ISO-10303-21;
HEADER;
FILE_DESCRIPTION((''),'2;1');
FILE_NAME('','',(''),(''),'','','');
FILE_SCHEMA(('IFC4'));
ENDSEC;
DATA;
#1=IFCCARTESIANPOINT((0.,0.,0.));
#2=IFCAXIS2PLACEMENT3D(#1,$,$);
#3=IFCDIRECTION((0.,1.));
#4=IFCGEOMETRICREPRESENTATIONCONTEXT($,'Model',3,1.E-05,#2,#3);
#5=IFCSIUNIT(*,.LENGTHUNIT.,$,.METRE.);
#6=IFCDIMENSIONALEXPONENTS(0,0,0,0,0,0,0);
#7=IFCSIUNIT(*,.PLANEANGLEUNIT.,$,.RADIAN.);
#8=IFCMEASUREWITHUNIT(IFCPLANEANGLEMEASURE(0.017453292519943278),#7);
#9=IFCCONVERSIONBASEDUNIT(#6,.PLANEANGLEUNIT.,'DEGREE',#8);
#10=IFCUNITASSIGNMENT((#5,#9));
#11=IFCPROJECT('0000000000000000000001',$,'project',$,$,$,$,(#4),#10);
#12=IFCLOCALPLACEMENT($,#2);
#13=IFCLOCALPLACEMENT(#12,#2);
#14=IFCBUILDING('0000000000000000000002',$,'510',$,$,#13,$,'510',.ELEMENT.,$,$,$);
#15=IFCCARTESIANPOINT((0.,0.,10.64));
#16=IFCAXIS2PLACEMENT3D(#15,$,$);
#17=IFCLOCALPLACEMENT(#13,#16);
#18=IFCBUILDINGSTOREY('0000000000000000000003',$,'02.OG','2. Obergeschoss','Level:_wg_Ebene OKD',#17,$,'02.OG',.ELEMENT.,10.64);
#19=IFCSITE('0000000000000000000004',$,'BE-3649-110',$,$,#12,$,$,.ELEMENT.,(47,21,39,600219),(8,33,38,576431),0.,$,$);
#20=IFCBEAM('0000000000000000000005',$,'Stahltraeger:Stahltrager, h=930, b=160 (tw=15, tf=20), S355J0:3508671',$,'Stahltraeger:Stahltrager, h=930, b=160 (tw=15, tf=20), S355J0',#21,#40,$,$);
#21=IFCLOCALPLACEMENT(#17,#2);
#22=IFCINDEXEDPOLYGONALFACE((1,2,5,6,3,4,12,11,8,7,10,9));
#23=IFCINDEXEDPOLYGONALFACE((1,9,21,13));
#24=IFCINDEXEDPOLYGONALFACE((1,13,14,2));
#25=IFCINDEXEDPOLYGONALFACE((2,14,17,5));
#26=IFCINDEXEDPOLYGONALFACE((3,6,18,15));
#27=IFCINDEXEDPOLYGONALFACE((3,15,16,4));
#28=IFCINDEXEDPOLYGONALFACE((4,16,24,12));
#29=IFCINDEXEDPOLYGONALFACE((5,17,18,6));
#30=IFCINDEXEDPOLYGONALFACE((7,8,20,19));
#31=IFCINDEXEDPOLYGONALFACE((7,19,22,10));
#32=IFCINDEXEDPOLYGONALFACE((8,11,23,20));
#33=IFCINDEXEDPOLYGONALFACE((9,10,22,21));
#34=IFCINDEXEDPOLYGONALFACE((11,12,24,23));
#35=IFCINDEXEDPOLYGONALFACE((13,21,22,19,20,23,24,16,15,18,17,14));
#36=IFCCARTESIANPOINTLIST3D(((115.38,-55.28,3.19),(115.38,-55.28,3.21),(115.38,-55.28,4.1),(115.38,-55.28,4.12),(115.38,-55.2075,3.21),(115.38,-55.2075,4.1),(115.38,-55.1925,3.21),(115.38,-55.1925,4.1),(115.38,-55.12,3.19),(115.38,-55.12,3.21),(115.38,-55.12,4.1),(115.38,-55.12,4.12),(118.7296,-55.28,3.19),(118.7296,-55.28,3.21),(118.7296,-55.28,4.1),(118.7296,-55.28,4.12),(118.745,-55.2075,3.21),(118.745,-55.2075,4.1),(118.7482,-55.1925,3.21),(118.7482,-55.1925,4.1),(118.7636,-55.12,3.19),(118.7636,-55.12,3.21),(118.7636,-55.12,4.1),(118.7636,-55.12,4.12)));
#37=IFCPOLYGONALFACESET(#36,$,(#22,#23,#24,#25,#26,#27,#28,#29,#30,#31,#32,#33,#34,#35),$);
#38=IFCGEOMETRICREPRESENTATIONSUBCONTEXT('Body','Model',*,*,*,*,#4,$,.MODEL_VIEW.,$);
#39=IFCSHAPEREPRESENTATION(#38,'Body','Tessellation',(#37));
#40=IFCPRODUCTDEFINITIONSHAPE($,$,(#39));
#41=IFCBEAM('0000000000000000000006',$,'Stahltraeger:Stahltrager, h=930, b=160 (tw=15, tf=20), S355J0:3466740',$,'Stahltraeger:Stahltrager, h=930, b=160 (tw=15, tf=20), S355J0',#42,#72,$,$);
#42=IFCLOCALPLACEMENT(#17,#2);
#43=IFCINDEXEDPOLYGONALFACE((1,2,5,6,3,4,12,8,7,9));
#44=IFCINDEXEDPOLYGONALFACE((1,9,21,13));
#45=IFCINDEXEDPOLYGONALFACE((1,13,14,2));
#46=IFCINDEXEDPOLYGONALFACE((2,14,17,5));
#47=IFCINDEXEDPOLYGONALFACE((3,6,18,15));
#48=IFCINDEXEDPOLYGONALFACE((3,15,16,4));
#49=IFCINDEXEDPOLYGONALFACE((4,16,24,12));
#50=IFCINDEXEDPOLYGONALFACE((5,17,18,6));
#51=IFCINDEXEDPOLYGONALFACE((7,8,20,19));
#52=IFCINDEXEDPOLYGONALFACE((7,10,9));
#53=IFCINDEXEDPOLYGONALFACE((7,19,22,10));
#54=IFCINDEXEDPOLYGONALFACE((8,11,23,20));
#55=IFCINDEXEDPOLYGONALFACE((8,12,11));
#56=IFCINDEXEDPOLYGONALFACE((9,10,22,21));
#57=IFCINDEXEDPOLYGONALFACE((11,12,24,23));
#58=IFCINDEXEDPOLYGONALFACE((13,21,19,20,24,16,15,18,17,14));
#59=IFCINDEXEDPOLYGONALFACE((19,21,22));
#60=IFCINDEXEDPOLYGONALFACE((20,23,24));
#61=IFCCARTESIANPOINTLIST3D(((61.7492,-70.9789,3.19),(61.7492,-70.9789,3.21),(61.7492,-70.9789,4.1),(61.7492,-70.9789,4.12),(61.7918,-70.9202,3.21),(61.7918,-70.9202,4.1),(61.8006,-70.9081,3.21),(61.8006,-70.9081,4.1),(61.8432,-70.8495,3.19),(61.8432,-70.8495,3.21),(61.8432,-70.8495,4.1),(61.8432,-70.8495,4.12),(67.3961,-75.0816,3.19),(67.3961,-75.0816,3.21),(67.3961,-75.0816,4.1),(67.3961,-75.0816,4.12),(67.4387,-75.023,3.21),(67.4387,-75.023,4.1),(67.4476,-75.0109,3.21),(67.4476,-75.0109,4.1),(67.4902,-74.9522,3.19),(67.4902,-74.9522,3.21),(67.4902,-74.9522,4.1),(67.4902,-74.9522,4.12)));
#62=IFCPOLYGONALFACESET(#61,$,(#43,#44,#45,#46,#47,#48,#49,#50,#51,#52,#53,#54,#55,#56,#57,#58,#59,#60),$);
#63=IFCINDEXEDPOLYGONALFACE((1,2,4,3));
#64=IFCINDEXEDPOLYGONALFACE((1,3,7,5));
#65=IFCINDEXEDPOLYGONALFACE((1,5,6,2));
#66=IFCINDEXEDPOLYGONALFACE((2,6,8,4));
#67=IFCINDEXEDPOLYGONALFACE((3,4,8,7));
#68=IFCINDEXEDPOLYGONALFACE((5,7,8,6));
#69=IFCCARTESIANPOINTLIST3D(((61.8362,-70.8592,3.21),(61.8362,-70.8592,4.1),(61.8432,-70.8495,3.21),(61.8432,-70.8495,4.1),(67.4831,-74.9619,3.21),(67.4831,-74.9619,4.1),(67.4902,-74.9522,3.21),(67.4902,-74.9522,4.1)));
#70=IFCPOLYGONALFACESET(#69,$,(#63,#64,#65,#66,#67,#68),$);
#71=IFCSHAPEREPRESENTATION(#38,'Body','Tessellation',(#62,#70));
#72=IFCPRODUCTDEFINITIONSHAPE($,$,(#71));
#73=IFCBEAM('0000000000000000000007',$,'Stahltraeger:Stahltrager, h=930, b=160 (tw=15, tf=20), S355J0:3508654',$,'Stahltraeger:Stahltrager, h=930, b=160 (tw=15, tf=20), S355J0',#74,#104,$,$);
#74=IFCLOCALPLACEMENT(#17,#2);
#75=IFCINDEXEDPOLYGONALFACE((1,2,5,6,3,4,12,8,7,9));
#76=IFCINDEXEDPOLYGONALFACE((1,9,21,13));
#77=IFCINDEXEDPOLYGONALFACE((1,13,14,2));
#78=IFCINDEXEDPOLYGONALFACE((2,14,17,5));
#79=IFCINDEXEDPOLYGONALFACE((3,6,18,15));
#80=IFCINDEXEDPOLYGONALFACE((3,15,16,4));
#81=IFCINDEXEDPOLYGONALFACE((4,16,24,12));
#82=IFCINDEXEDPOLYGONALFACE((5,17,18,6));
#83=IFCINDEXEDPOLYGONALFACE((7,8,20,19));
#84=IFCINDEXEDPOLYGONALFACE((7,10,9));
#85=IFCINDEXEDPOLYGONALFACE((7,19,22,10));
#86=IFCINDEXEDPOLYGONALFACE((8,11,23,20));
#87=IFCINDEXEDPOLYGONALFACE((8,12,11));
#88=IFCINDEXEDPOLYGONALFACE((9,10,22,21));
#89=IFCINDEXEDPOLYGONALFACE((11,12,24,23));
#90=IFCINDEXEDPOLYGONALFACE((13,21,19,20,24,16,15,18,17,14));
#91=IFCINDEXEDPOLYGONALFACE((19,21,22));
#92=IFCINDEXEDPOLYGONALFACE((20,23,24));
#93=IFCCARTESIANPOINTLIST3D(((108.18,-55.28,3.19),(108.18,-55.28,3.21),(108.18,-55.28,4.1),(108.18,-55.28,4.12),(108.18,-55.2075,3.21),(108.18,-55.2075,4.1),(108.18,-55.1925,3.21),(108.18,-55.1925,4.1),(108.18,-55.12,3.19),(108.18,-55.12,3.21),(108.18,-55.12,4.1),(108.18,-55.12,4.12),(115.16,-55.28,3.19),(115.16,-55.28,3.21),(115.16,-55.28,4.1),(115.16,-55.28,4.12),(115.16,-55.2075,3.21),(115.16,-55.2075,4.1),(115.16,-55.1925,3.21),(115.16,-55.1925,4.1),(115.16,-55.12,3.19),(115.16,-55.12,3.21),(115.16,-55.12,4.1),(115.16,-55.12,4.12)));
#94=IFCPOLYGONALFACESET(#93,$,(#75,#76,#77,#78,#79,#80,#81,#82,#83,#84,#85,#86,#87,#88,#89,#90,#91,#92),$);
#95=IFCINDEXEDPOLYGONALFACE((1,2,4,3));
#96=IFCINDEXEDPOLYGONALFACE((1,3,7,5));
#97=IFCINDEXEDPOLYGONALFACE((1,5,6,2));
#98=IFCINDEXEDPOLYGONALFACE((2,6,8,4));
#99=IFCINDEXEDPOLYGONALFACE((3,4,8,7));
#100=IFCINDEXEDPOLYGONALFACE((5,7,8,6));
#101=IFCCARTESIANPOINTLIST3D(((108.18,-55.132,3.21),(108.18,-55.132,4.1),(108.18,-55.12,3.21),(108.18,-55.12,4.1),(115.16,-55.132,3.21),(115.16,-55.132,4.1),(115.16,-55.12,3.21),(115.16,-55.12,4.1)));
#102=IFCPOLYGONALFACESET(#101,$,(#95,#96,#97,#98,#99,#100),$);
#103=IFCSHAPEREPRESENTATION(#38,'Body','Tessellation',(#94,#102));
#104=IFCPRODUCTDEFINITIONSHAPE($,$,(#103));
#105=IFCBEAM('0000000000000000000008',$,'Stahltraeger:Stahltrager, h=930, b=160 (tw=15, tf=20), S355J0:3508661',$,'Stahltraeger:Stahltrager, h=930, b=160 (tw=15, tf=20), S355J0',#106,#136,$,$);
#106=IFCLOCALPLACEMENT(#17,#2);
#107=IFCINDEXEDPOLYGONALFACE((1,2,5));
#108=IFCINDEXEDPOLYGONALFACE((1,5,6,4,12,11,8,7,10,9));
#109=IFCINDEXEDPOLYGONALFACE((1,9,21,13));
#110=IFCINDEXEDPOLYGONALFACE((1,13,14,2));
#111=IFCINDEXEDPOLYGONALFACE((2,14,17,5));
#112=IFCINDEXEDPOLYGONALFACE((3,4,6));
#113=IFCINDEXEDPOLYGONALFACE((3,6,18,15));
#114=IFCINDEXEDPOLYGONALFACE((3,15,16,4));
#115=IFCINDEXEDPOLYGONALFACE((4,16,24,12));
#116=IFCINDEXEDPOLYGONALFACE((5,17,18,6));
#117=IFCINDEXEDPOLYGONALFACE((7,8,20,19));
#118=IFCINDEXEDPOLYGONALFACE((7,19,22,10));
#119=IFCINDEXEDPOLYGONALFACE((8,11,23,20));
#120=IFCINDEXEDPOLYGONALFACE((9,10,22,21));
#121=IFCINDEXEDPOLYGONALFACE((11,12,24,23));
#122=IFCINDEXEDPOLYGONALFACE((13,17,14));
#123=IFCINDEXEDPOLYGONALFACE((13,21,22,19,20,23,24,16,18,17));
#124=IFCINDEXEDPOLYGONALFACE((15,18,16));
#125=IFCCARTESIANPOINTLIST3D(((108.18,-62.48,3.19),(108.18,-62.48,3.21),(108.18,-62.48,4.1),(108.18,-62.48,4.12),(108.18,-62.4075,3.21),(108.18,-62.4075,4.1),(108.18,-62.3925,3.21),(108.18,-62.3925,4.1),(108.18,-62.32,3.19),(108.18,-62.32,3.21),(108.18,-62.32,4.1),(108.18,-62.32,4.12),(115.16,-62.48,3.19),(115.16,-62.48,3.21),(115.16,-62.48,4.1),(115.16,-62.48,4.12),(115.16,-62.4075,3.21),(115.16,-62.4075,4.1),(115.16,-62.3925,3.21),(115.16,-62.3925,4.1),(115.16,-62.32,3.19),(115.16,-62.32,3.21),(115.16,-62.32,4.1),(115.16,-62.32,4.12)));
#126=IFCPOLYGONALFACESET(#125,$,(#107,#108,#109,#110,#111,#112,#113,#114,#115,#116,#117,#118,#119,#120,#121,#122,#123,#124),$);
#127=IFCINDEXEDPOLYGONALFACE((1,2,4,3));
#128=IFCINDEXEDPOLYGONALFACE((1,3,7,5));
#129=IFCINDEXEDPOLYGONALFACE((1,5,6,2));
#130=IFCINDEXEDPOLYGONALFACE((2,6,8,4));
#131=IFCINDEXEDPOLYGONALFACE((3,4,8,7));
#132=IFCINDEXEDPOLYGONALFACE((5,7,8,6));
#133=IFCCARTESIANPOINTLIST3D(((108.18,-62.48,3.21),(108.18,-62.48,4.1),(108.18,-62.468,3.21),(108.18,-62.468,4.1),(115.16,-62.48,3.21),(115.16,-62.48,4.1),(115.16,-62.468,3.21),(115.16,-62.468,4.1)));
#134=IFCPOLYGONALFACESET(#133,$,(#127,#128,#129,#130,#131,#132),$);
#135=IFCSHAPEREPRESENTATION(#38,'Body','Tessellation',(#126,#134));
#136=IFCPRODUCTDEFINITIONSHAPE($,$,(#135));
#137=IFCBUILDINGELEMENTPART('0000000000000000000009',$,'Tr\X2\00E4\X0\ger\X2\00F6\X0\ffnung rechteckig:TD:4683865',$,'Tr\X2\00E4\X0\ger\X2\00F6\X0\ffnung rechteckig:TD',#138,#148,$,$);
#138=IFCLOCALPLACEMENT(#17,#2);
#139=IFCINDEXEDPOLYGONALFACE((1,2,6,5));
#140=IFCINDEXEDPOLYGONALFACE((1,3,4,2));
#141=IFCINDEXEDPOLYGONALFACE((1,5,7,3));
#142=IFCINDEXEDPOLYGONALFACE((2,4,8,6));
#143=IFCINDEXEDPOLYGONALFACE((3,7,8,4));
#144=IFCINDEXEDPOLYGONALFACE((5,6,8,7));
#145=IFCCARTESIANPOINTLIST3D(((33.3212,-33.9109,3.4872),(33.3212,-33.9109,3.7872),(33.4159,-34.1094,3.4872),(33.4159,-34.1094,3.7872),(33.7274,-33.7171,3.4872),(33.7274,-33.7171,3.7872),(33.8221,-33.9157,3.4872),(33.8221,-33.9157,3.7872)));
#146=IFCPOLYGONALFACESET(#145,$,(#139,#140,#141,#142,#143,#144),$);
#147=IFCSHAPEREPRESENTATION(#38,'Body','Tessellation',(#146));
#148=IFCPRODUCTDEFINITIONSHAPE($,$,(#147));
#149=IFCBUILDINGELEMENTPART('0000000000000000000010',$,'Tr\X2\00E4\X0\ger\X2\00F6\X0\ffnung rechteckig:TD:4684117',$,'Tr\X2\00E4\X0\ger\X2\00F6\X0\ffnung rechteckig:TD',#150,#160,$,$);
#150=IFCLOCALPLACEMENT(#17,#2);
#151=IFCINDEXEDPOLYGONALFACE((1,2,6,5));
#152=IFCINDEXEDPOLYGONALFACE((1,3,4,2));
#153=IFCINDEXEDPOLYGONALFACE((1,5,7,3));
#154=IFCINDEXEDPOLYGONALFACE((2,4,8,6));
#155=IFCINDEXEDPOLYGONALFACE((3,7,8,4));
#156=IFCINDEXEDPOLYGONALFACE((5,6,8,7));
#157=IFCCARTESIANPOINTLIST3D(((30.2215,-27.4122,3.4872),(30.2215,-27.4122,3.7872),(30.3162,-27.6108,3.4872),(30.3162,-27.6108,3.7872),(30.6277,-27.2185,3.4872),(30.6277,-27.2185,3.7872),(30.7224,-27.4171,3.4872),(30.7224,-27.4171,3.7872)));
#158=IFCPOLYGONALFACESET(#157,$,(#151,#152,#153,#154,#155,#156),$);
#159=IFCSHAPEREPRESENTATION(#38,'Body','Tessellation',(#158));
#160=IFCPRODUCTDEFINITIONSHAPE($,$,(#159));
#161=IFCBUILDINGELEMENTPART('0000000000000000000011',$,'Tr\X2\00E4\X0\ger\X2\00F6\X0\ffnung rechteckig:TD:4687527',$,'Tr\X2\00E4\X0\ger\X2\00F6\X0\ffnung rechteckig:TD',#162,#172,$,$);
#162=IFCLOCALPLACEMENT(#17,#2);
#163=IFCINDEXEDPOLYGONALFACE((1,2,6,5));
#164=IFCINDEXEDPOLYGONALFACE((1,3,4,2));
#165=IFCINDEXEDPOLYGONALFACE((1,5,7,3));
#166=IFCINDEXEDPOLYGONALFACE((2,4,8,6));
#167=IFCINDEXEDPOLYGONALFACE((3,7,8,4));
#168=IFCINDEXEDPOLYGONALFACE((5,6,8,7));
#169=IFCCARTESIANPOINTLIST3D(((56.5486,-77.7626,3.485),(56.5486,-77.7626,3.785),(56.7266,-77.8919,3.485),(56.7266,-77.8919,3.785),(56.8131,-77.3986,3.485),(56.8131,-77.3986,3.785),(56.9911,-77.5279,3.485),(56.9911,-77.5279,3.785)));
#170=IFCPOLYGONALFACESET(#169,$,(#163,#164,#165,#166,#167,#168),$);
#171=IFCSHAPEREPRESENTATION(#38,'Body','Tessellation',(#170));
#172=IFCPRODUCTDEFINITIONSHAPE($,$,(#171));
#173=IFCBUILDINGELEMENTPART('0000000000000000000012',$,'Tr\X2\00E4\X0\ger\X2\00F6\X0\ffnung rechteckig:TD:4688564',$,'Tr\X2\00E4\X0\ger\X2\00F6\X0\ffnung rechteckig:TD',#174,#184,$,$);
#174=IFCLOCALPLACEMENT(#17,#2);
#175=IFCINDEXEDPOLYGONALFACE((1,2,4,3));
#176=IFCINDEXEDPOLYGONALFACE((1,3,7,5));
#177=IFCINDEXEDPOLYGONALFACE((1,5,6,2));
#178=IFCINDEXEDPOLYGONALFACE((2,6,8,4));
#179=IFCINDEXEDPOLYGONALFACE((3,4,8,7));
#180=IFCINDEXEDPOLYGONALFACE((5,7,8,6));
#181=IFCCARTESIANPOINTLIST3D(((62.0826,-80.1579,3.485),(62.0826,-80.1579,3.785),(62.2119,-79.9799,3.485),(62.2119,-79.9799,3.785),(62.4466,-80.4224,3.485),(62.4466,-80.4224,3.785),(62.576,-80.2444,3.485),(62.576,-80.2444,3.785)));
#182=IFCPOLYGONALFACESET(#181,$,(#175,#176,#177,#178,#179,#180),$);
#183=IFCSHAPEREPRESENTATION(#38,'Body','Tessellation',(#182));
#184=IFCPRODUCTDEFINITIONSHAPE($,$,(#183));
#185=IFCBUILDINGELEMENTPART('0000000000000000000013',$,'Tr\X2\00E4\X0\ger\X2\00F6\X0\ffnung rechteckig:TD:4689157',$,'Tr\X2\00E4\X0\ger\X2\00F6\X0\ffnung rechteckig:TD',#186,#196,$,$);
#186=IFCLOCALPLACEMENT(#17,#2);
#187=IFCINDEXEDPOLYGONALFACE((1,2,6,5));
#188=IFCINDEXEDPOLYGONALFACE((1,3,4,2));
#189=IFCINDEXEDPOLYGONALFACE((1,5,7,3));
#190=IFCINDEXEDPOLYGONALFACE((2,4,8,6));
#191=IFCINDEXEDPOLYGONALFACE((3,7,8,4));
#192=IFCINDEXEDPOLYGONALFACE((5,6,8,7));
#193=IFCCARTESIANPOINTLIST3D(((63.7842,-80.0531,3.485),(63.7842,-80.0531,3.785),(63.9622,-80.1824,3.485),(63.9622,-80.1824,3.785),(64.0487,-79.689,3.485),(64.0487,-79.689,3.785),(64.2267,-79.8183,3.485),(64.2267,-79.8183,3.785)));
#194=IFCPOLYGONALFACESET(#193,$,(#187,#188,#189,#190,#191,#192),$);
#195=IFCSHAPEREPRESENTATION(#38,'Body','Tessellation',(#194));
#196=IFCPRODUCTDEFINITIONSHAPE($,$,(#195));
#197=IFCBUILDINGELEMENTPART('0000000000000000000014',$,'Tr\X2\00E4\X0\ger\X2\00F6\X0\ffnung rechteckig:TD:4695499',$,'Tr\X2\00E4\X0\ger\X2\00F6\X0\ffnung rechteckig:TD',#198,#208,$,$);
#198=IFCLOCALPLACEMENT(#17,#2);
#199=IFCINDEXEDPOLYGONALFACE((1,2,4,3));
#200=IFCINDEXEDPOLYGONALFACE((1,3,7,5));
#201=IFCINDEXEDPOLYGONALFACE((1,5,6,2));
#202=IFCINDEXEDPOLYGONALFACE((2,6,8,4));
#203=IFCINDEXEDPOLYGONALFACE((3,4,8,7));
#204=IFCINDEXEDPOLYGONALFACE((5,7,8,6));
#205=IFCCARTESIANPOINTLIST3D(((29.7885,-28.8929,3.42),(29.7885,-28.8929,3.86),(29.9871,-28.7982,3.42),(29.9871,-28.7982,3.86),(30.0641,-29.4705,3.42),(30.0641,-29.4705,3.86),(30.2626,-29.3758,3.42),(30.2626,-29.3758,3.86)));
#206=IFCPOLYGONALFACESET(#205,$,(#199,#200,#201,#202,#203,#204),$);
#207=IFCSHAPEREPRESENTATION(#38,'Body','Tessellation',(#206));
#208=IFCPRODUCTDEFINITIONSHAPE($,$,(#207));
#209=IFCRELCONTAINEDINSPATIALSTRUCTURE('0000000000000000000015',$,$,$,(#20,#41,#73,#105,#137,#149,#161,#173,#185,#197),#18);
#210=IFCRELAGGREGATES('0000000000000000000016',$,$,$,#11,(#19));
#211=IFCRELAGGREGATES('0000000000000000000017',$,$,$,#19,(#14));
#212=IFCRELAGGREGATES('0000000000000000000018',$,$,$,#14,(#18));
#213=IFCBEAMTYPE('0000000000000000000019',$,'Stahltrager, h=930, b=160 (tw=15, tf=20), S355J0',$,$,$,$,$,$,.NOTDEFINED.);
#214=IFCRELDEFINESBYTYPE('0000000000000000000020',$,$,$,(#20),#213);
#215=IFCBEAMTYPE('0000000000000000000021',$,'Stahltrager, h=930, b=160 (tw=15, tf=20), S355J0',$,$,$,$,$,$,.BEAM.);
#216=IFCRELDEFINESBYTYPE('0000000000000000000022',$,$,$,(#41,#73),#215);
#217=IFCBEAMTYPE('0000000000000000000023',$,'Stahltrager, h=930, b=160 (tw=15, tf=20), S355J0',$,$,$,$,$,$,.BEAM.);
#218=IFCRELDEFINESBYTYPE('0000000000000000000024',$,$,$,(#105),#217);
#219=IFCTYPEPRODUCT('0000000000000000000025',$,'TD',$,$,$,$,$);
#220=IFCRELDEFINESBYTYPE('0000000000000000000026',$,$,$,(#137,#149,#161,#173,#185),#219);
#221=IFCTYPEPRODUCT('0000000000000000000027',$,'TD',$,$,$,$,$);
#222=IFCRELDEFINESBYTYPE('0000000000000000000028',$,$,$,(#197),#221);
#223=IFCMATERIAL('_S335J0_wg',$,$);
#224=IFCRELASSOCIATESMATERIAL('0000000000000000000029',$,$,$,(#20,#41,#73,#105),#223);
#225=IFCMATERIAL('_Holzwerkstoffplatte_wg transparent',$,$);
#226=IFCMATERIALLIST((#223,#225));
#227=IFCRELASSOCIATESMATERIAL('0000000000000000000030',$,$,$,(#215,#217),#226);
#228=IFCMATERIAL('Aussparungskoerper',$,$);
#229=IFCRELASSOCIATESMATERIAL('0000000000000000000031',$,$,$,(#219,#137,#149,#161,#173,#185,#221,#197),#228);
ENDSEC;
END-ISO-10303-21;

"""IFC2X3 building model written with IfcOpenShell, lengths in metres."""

from ifc_helpers import new_model, entity, si_unit, converted_unit, direction, frame, frame_2d, origin, origin_2d_with_axis, place, context, subcontext, project, spatial, rectangle, i_section, extrude, clip, halfspace, source, transform, mapped, material, material_list, type_object, type_shapes, element, save


model = new_model("IFC2X3")

# Units and contexts
model_context = context("Model", 3, precision=1e-05, world=origin(), true_north=direction((0.0, 1.0)))
body_context = subcontext(model_context, "Body", "Model", "MODEL_VIEW")
ifc_project = project(units=[si_unit("LENGTHUNIT", "METRE"), converted_unit("PLANEANGLEUNIT", "DEGREE", entity("IfcPlaneAngleMeasure", 0.017453292519943278), si_unit("PLANEANGLEUNIT", "RADIAN"), dimensions=[0, 0, 0, 0, 0, 0, 0])], contexts=[model_context])

# Site, building, storey
site_placement = place(None, origin())
site = spatial("IfcSite", under=ifc_project, at=site_placement, Name="BE-3649-110", CompositionType="ELEMENT", RefLatitude=(47, 21, 39, 600219), RefLongitude=(8, 33, 38, 576431), RefElevation=0.0)
building_placement = place(site_placement, origin())
building = spatial("IfcBuilding", under=site, at=building_placement, Name="510", LongName="510", CompositionType="ELEMENT")
storey_placement = place(building_placement, frame((0.0, 0.0, 10.64)))
storey = spatial("IfcBuildingStorey", under=building, at=storey_placement, Name="02.OG", Description="2. Obergeschoss", ObjectType="Level:_wg_Ebene OKD", LongName="02.OG", CompositionType="ELEMENT", Elevation=10.64)

# Beams
ifc_material_1 = material(Name="_S335J0_wg")
beam_type_1 = type_object("IfcBeamType", Name="Stahltrager, h=930, b=160 (tw=15, tf=20), S355J0", PredefinedType="NOTDEFINED")
beam_1_placement = place(storey_placement, frame((115.38, -55.2, 4.12)))
element("IfcBeam", 1, at=beam_1_placement, inside=storey, type_object=beam_type_1, material=ifc_material_1, Name="Stahltraeger:Stahltrager, h=930, b=160 (tw=15, tf=20), S355J0:3508671", ObjectType="Stahltraeger:Stahltrager, h=930, b=160 (tw=15, tf=20), S355J0", context=body_context, shape_type="SweptSolid", body=[
    clip(extrude(i_section(OverallWidth=0.16, OverallDepth=0.93, WebThickness=0.015, FlangeThickness=0.02, at=frame_2d((0.0, 0.0), x_axis=(0.0, 1.0))), frame((0.0, 0.0, -0.465), z_axis=(1.0, 0.0, 0.0), x_axis=(0.0, 0.0, -1.0)), (0.0, 0.0, 1.0), 3.3836), halfspace(frame((3.2599, -0.5018, 10.02), z_axis=(0.978148, -0.207912, 0.0), x_axis=(0.207912, 0.978148, 0.0)), False)),
])
ifc_material_2 = material(Name="_Holzwerkstoffplatte_wg transparent")
ifc_material_list = material_list([ifc_material_1, ifc_material_2])
beam_type_2 = type_object("IfcBeamType", Name="Stahltrager, h=930, b=160 (tw=15, tf=20), S355J0", PredefinedType="BEAM", material=ifc_material_list)
shared_shape_1 = source(origin(), body_context, "Body", "SweptSolid", [
    extrude(i_section(OverallWidth=0.16, OverallDepth=0.93, WebThickness=0.015, FlangeThickness=0.02, at=frame_2d((0.0, 0.0), x_axis=(0.0, 1.0))), frame((-3.49, 0.0, 0.0), z_axis=(1.0, 0.0, 0.0), x_axis=(0.0, 0.0, -1.0)), (0.0, 0.0, 1.0), 6.98),
    extrude(rectangle(XDim=0.89, YDim=0.012, at=origin_2d_with_axis()), frame((-3.49, 0.074, 0.0), z_axis=(1.0, 0.0, 0.0), x_axis=(0.0, 0.0, -1.0)), (0.0, 0.0, 1.0), 6.98),
])
type_shapes(beam_type_2, [shared_shape_1])
beam_2_placement = place(storey_placement, frame((64.6197, -72.9655, 3.655), z_axis=(0.0, 0.0, 1.0), x_axis=(0.809017, -0.587785, 0.0)))
element("IfcBeam", 2, at=beam_2_placement, inside=storey, type_object=beam_type_2, material=ifc_material_1, Name="Stahltraeger:Stahltrager, h=930, b=160 (tw=15, tf=20), S355J0:3466740", ObjectType="Stahltraeger:Stahltrager, h=930, b=160 (tw=15, tf=20), S355J0", context=body_context, shape_type="MappedRepresentation", body=[
    mapped(shared_shape_1, transform((0.0, 0.0, 0.0), scale=1.0)),
])
beam_3_placement = place(storey_placement, frame((111.67, -55.2, 3.655)))
element("IfcBeam", 3, at=beam_3_placement, inside=storey, type_object=beam_type_2, material=ifc_material_1, Name="Stahltraeger:Stahltrager, h=930, b=160 (tw=15, tf=20), S355J0:3508654", ObjectType="Stahltraeger:Stahltrager, h=930, b=160 (tw=15, tf=20), S355J0", context=body_context, shape_type="MappedRepresentation", body=[
    mapped(shared_shape_1, transform((0.0, 0.0, 0.0), scale=1.0)),
])
beam_type_3 = type_object("IfcBeamType", Name="Stahltrager, h=930, b=160 (tw=15, tf=20), S355J0", PredefinedType="BEAM", material=ifc_material_list)
shared_shape_2 = source(origin(), body_context, "Body", "SweptSolid", [
    extrude(i_section(OverallWidth=0.16, OverallDepth=0.93, WebThickness=0.015, FlangeThickness=0.02, at=frame_2d((0.0, 0.0), x_axis=(0.0, 1.0))), frame((-3.49, 0.0, 0.0), z_axis=(1.0, 0.0, 0.0), x_axis=(0.0, 0.0, -1.0)), (0.0, 0.0, 1.0), 6.98),
    extrude(rectangle(XDim=0.89, YDim=0.012, at=frame_2d((0.0, 0.0), x_axis=(1.0, 0.0))), frame((-3.49, -0.074, 0.0), z_axis=(1.0, 0.0, 0.0), x_axis=(0.0, 0.0, -1.0)), (0.0, 0.0, 1.0), 6.98),
])
type_shapes(beam_type_3, [shared_shape_2])
beam_4_placement = place(storey_placement, frame((111.67, -62.4, 3.655)))
element("IfcBeam", 4, at=beam_4_placement, inside=storey, type_object=beam_type_3, material=ifc_material_1, Name="Stahltraeger:Stahltrager, h=930, b=160 (tw=15, tf=20), S355J0:3508661", ObjectType="Stahltraeger:Stahltrager, h=930, b=160 (tw=15, tf=20), S355J0", context=body_context, shape_type="MappedRepresentation", body=[
    mapped(shared_shape_2, transform((0.0, 0.0, 0.0), scale=1.0)),
])

# Building element parts
ifc_material_3 = material(Name="Aussparungskoerper")
type_product_1 = type_object("IfcTypeProduct", Name="TD", material=ifc_material_3)
shared_shape_3 = source(origin(), body_context, "Body", "SweptSolid", [
    extrude(rectangle(XDim=0.45, YDim=0.3, at=origin_2d_with_axis()), frame((0.0, 0.0, -0.22), z_axis=(0.0, 0.0, 1.0), x_axis=(-1.0, 0.0, 0.0)), (0.0, 0.0, 1.0), 0.22),
])
type_shapes(type_product_1, [shared_shape_3])
for number, where, z_axis, x_axis, name in (
    (5, (33.619, -34.0126, 3.6372), (0.430511, -0.902585, 0.0), (-0.902585, -0.430511, 0.0), "Trägeröffnung rechteckig:TD:4683865"),
    (6, (30.5193, -27.5139, 3.6372), (0.430511, -0.902585, 0.0), (-0.902585, -0.430511, 0.0), "Trägeröffnung rechteckig:TD:4684117"),
    (7, (56.8588, -77.7099, 3.635), (0.809017, -0.587785, 0.0), (-0.587785, -0.809017, 0.0), "Trägeröffnung rechteckig:TD:4687527"),
    (8, (62.2646, -80.2901, 3.635), (-0.587785, -0.809017, 0.0), (0.809017, -0.587785, 0.0), "Trägeröffnung rechteckig:TD:4688564"),
    (9, (64.0944, -80.0003, 3.635), (0.809017, -0.587785, 0.0), (-0.587785, -0.809017, 0.0), "Trägeröffnung rechteckig:TD:4689157"),
):
    element("IfcBuildingElementPart", number, at=place(storey_placement, frame(where, z_axis=z_axis, x_axis=x_axis)), inside=storey, type_object=type_product_1, material=ifc_material_3, Name=name, ObjectType="Trägeröffnung rechteckig:TD", context=body_context, shape_type="MappedRepresentation", body=[
        mapped(shared_shape_3, transform((0.0, 0.0, 0.0), scale=1.0)),
    ])
type_product_2 = type_object("IfcTypeProduct", Name="TD", material=ifc_material_3)
shared_shape_4 = source(origin(), body_context, "Body", "SweptSolid", [
    extrude(rectangle(XDim=0.22, YDim=0.64, at=origin_2d_with_axis()), frame((30.0256, -29.1344, -0.44), z_axis=(0.0, 0.0, 1.0), x_axis=(-0.902585, -0.430511, 0.0)), (0.0, 0.0, 1.0), 0.44),
])
type_shapes(type_product_2, [shared_shape_4])
building_element_part_1_placement = place(storey_placement, frame((0.0, 0.0, 3.86)))
element("IfcBuildingElementPart", 10, at=building_element_part_1_placement, inside=storey, type_object=type_product_2, material=ifc_material_3, Name="Trägeröffnung rechteckig:TD:4695499", ObjectType="Trägeröffnung rechteckig:TD", context=body_context, shape_type="MappedRepresentation", body=[
    mapped(shared_shape_4, transform((0.0, 0.0, 0.0), scale=1.0)),
])

save(model, "model.ifc")
